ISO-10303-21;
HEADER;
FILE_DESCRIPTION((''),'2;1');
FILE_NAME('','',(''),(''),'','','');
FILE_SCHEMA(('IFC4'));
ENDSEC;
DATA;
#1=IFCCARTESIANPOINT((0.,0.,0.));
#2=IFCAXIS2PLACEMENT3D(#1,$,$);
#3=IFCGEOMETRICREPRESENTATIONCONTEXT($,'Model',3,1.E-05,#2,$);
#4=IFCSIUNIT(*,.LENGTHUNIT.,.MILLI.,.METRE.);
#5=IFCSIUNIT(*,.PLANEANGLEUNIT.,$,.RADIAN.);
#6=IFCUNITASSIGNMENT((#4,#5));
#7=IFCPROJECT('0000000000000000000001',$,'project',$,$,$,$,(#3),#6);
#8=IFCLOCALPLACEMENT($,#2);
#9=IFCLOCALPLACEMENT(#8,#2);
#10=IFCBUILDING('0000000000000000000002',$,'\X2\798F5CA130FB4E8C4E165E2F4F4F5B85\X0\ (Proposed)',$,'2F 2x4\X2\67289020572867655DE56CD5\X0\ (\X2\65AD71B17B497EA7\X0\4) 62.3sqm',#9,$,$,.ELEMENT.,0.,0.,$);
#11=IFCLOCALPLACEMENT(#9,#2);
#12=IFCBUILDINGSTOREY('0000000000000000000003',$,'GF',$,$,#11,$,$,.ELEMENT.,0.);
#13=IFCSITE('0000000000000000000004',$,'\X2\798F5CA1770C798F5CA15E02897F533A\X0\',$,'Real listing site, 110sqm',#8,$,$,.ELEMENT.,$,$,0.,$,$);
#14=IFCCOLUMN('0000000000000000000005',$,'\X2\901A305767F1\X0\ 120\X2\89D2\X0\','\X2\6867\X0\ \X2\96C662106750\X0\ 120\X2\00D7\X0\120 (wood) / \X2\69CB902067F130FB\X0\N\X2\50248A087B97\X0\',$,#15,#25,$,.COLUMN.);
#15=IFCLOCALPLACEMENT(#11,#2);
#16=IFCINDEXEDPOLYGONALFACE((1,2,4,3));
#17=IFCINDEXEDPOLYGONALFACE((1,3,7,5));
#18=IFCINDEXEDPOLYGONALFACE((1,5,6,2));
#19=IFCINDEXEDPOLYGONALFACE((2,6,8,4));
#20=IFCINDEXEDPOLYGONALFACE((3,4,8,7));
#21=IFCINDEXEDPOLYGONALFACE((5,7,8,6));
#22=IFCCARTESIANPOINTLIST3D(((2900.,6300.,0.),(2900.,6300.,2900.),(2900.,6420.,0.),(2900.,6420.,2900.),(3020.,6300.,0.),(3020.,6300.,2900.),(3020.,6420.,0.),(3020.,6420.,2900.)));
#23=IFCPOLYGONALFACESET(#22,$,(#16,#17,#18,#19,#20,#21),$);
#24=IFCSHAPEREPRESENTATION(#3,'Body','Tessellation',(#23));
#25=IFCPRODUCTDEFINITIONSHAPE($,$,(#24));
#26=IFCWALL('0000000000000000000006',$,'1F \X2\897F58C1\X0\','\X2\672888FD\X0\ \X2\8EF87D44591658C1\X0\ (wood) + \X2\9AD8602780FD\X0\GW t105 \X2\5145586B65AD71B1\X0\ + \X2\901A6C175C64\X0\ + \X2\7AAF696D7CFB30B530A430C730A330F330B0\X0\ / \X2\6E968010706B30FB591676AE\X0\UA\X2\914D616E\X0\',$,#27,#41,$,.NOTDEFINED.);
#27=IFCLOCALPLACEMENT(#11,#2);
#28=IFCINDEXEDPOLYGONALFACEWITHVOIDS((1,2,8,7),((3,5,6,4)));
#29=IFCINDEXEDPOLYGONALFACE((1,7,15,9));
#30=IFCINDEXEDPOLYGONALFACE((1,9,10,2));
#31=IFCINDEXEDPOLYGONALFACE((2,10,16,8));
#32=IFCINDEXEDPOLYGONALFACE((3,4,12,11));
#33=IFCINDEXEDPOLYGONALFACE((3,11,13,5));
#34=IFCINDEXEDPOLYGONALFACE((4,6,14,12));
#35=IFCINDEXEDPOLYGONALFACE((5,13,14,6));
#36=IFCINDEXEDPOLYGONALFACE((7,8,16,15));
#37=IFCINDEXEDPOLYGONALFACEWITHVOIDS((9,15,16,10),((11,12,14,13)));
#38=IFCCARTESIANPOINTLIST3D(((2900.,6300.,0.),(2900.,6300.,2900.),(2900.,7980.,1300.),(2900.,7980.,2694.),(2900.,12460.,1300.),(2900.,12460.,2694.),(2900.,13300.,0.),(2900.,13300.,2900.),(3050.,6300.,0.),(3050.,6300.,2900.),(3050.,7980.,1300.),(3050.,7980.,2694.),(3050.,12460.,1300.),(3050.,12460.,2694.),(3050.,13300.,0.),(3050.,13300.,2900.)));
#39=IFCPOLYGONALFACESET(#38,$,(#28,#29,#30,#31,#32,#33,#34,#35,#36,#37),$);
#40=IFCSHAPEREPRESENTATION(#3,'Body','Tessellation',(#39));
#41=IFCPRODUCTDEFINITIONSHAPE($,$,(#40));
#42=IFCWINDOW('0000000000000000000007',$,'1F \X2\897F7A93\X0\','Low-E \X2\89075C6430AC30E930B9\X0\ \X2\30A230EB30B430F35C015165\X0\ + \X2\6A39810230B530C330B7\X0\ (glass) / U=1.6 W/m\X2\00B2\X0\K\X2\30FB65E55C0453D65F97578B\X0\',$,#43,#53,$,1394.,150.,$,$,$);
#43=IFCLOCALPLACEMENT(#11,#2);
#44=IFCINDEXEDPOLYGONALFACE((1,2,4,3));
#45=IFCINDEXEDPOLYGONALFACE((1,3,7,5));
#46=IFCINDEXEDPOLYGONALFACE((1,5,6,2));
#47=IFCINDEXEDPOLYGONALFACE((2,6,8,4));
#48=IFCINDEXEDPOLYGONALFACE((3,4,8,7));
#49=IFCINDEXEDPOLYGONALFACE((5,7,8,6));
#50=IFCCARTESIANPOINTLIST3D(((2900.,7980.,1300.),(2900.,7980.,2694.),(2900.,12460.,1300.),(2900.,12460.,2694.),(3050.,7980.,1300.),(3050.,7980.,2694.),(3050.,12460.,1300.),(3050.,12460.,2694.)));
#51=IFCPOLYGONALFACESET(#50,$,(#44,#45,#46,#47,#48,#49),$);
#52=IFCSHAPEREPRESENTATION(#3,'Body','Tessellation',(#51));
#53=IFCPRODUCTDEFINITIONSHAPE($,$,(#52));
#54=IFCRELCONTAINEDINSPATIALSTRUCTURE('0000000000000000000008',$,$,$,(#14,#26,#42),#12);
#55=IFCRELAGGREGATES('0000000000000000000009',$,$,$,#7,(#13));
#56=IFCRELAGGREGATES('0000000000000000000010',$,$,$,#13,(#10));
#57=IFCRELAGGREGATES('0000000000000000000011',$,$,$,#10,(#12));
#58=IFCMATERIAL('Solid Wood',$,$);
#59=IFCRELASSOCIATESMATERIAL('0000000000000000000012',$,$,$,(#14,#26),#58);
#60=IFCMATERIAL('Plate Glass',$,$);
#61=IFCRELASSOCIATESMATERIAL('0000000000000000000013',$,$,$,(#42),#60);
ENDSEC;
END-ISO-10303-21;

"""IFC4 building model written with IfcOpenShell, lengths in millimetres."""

from ifc_helpers import new_model, si_unit, frame, frame_2d, origin, place, context, project, spatial, rectangle, extrude, material, element, fill, save


model = new_model("IFC4")

# Units and contexts
model_context = context("Model", 3, precision=1e-05, world=origin())
ifc_project = project(units=[si_unit("LENGTHUNIT", "METRE", prefix="MILLI"), si_unit("PLANEANGLEUNIT", "RADIAN")], contexts=[model_context])

# Site, building, storey
site_placement = place(None, origin())
site = spatial("IfcSite", under=ifc_project, at=site_placement, Name="福岡県福岡市西区", ObjectType="Real listing site, 110sqm", CompositionType="ELEMENT", RefElevation=0.0)
building_placement = place(site_placement, origin())
building = spatial("IfcBuilding", under=site, at=building_placement, Name="福岡・二世帯住宅 (Proposed)", ObjectType="2F 2x4木造在来工法 (断熱等级4) 62.3sqm", CompositionType="ELEMENT", ElevationOfRefHeight=0.0, ElevationOfTerrain=0.0)
storey_placement = place(building_placement, origin())
storey = spatial("IfcBuildingStorey", under=building, at=storey_placement, Name="GF", CompositionType="ELEMENT", Elevation=0.0)

# Column
ifc_material_1 = material(Name="Solid Wood")
column_1_placement = place(storey_placement, frame((1450.0, 3150.0, 0.0)))
element("IfcColumn", 1, at=column_1_placement, inside=storey, material=ifc_material_1, Name="通し柱 120角", Description="桧 集成材 120×120 (wood) / 構造柱・N値計算", PredefinedType="COLUMN", context=model_context, shape_type="SweptSolid", body=[
    extrude(rectangle(XDim=120.0, YDim=120.0, at=frame_2d((60.0, 60.0))), frame((1450.0, 3150.0, 0.0)), (0.0, 0.0, 1.0), 2900.0),
])

# Shared definitions
ifc_material_2 = material(Name="Plate Glass")

# Wall, opening, window
wall_1_placement = place(storey_placement, frame((1450.0, 3150.0, 0.0)))
wall_1 = element("IfcWall", 2, at=wall_1_placement, inside=storey, material=ifc_material_1, Name="1F 西壁", Description="木製 軸組外壁 (wood) + 高性能GW t105 充填断熱 + 通気層 + 窯業系サイディング / 準耐火・外皮UA配慮", PredefinedType="NOTDEFINED", context=model_context, shape_type="SweptSolid", body=[
    extrude(rectangle(XDim=150.0, YDim=7000.0, at=frame_2d((75.0, 3500.0))), frame((1450.0, 3150.0, 0.0)), (0.0, 0.0, 1.0), 2900.0),
])
opening_1_placement = place(storey_placement, frame((1450.0, 3990.0, 650.0)))
opening_1 = element("IfcOpeningElement", 3, at=opening_1_placement, cuts=wall_1, PredefinedType="NOTDEFINED", context=model_context, shape_type="SweptSolid", body=[
    extrude(rectangle(XDim=150.0, YDim=4480.0, at=frame_2d((75.0, 2240.0))), frame((1450.0, 3990.0, 650.0)), (0.0, 0.0, 1.0), 1394.0),
])
window_1_placement = place(storey_placement, frame((1450.0, 3990.0, 650.0)))
window_1 = element("IfcWindow", 4, at=window_1_placement, inside=storey, material=ifc_material_2, Name="1F 西窓", Description="Low-E 複層ガラス アルゴン封入 + 樹脂サッシ (glass) / U=1.6 W/m²K・日射取得型", OverallHeight=1394.0, OverallWidth=150.0, context=model_context, shape_type="SweptSolid", body=[
    extrude(rectangle(XDim=150.0, YDim=4480.0, at=frame_2d((75.0, 2240.0))), frame((1450.0, 3990.0, 650.0)), (0.0, 0.0, 1.0), 1394.0),
])
fill(opening_1, window_1)

save(model, "model.ifc")
